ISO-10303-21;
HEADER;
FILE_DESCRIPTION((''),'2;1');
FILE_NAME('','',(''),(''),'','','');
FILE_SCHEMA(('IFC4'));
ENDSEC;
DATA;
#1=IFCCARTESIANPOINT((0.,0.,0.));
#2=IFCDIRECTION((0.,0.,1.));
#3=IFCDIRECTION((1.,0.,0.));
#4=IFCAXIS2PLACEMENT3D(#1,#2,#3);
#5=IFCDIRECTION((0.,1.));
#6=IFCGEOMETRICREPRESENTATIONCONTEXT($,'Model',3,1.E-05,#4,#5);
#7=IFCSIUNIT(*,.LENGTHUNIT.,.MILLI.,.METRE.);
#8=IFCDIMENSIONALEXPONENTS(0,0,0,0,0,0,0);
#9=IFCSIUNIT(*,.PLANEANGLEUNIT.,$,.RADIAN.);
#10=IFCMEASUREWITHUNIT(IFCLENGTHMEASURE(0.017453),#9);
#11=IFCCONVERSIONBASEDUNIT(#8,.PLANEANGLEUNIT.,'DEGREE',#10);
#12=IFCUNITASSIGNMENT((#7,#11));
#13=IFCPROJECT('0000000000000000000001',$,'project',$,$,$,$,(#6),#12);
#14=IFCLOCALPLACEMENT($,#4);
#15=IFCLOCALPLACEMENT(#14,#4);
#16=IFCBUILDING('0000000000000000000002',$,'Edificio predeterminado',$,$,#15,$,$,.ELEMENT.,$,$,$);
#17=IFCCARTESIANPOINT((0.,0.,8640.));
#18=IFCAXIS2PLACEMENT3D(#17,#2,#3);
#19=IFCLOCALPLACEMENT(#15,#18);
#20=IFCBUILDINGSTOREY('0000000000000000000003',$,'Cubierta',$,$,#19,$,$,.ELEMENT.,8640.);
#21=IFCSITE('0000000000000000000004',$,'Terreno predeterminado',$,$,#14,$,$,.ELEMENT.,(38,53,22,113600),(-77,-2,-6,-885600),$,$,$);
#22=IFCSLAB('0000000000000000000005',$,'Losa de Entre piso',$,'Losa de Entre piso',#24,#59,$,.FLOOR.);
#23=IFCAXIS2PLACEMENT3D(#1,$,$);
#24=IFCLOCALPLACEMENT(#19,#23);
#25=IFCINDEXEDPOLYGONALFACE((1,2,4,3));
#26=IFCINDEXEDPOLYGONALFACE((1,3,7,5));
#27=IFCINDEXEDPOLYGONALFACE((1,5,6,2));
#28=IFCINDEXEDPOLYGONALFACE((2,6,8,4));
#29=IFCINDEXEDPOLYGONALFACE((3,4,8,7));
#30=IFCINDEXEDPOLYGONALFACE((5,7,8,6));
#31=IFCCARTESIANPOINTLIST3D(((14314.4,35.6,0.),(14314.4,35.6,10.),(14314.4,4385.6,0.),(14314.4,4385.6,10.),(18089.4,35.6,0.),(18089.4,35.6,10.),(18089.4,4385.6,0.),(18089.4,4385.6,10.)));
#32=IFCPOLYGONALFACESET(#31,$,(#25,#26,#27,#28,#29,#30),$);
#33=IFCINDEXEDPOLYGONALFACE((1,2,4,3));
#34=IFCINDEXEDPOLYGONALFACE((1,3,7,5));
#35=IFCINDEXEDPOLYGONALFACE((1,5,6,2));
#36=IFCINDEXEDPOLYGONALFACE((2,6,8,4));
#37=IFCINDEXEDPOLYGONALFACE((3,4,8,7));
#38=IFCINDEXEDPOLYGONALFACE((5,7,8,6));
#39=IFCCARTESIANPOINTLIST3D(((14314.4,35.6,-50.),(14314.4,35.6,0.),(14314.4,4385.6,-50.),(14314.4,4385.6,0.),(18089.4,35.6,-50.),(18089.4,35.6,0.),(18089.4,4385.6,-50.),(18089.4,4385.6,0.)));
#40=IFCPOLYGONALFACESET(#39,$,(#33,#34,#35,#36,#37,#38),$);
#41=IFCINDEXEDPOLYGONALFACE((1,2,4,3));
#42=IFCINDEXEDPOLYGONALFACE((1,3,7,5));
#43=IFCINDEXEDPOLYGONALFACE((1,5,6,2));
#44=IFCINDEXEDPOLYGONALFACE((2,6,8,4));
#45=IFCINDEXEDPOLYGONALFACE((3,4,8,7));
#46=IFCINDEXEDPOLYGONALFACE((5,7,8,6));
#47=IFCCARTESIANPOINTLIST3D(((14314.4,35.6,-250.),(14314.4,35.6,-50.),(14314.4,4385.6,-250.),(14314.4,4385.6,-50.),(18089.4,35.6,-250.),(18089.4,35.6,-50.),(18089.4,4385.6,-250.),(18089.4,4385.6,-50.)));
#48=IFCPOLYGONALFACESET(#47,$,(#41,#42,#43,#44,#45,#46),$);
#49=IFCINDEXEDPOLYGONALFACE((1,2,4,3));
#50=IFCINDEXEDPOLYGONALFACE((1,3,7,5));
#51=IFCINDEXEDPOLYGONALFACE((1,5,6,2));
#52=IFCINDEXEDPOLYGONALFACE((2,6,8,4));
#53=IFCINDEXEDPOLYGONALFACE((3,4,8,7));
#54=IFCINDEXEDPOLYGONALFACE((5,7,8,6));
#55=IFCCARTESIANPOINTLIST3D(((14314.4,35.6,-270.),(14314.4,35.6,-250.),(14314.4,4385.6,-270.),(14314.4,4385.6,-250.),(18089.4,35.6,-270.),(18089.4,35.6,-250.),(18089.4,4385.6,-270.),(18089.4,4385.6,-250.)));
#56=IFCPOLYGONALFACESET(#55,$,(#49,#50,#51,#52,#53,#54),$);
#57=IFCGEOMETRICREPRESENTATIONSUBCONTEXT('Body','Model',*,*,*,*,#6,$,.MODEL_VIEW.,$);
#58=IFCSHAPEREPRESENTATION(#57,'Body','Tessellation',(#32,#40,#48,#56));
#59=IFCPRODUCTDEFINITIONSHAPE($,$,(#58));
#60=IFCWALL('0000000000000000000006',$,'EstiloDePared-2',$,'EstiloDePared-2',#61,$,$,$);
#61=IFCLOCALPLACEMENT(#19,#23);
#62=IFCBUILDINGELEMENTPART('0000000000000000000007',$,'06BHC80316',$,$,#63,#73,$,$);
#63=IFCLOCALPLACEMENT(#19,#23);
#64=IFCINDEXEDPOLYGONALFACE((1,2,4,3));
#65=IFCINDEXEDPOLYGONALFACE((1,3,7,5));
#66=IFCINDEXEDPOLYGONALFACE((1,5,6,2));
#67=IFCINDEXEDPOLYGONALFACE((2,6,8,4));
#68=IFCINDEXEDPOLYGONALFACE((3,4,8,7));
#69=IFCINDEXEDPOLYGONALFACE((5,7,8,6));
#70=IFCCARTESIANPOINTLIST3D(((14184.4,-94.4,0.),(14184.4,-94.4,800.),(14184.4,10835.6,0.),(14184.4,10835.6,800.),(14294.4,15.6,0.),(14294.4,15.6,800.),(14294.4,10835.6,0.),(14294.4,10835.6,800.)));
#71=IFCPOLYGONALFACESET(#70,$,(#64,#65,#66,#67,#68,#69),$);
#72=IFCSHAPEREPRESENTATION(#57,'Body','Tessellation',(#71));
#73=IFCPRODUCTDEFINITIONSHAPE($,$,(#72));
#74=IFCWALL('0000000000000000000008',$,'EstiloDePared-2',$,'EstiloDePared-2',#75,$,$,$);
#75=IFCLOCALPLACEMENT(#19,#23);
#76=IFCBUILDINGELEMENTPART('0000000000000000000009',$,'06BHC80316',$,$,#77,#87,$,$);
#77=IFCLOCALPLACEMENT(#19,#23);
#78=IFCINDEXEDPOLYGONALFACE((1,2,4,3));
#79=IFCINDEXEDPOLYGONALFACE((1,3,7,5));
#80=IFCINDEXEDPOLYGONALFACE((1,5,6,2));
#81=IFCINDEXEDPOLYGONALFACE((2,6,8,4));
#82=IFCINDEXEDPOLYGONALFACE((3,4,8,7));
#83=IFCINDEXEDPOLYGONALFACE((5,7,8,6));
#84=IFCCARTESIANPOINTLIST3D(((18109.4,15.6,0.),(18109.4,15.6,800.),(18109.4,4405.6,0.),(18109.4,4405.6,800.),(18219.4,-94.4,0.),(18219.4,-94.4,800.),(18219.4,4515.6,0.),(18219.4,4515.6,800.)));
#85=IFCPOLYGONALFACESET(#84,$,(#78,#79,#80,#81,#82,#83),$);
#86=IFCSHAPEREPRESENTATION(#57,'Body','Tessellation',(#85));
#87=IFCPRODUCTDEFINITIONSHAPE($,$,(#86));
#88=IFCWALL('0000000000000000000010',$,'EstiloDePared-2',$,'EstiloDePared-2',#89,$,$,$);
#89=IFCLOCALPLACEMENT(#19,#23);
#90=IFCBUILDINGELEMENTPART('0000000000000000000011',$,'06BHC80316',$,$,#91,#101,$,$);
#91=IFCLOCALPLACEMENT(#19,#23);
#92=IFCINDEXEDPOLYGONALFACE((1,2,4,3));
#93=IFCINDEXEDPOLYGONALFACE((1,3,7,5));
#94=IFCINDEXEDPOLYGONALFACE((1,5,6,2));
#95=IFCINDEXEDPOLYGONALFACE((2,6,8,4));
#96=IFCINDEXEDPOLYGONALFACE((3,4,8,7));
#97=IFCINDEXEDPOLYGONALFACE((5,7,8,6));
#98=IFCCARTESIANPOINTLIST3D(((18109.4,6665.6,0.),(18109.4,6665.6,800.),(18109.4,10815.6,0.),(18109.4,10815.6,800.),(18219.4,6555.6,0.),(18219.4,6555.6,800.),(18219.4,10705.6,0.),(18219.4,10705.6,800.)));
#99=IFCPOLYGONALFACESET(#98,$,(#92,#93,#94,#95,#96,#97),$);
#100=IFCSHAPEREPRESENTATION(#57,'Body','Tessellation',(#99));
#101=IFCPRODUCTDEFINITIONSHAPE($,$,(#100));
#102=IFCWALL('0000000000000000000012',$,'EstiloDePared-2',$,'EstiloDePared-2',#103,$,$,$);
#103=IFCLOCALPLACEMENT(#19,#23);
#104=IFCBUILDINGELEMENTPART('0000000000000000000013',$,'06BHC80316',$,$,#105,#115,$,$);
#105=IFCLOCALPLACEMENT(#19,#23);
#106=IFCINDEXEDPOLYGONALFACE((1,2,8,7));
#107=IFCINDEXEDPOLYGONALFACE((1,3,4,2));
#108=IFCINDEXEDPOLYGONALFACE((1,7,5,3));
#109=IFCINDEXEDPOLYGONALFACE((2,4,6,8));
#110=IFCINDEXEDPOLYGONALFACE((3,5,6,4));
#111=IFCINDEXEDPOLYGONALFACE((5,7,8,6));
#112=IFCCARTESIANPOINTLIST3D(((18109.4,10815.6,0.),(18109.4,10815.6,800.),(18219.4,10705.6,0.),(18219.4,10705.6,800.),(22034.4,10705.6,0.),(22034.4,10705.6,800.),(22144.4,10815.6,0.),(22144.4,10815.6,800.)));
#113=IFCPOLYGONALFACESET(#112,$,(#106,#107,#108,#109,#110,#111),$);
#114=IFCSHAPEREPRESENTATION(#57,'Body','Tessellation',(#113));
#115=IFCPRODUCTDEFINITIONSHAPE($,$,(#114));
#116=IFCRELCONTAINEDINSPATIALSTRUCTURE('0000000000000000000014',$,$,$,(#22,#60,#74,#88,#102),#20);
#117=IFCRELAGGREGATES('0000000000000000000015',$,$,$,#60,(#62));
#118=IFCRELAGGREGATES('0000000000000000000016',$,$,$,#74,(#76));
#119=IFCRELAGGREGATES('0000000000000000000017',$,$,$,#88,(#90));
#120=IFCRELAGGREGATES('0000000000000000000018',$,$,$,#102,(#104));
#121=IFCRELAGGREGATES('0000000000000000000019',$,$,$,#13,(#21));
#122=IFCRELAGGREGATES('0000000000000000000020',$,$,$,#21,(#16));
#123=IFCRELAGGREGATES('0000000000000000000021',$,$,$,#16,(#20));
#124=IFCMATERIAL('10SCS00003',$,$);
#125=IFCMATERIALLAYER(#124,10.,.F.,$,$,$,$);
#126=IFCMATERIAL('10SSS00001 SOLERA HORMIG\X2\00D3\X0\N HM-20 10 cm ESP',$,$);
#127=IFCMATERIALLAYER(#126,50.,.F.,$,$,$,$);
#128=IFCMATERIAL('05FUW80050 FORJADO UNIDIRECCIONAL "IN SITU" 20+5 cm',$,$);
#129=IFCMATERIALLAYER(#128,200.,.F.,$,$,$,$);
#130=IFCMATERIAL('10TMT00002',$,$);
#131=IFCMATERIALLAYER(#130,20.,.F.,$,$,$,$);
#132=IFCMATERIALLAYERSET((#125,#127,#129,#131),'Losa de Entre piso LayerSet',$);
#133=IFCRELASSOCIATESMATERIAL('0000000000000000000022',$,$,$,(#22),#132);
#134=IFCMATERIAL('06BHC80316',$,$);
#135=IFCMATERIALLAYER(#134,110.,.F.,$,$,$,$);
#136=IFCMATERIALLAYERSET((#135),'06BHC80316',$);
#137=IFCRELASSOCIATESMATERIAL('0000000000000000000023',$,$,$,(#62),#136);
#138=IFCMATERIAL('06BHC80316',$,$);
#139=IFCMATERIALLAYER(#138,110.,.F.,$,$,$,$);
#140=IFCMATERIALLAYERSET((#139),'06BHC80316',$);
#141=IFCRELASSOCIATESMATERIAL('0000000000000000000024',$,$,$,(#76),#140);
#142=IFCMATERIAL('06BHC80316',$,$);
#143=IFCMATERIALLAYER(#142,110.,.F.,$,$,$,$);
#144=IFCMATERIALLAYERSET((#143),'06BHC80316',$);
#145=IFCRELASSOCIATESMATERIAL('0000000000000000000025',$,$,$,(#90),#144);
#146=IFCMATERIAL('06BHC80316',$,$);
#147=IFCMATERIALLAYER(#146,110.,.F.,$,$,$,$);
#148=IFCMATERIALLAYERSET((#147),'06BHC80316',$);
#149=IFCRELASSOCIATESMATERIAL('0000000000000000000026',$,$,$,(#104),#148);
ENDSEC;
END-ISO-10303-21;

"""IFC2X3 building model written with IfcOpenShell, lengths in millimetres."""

from ifc_helpers import new_model, entity, si_unit, converted_unit, direction, frame, origin_with_axes, place, context, subcontext, project, spatial, polyline, outline, extrude, material, layer, layer_set, layer_usage, element, aggregate, save


model = new_model("IFC2X3")

# Units and contexts
model_context = context("Model", 3, precision=1e-05, world=origin_with_axes(), true_north=direction((0.0, 1.0)))
body_context = subcontext(model_context, "Body", "Model", "MODEL_VIEW")
ifc_project = project(units=[si_unit("LENGTHUNIT", "METRE", prefix="MILLI"), converted_unit("PLANEANGLEUNIT", "DEGREE", entity("IfcLengthMeasure", 0.017453), si_unit("PLANEANGLEUNIT", "RADIAN"), dimensions=[0, 0, 0, 0, 0, 0, 0])], contexts=[model_context])

# Site, building, storey
site_placement = place(None, origin_with_axes())
site = spatial("IfcSite", under=ifc_project, at=site_placement, Name="Terreno predeterminado", CompositionType="ELEMENT", RefLatitude=(38, 53, 22, 113600), RefLongitude=(-77, -2, -6, -885600))
building_placement = place(site_placement, origin_with_axes())
building = spatial("IfcBuilding", under=site, at=building_placement, Name="Edificio predeterminado", CompositionType="ELEMENT")
storey_placement = place(building_placement, frame((0.0, 0.0, 8640.0), z_axis=(0.0, 0.0, 1.0), x_axis=(1.0, 0.0, 0.0)))
storey = spatial("IfcBuildingStorey", under=building, at=storey_placement, Name="Cubierta", CompositionType="ELEMENT", Elevation=8640.0)

# Slab
ifc_material_1 = material(Name="10SCS00003")
ifc_layer_1 = layer(ifc_material_1, 10.0, ventilated=False)
ifc_material_2 = material(Name="10SSS00001 SOLERA HORMIGÓN HM-20 10 cm ESP")
ifc_layer_2 = layer(ifc_material_2, 50.0, ventilated=False)
ifc_material_3 = material(Name="05FUW80050 FORJADO UNIDIRECCIONAL \"IN SITU\" 20+5 cm")
ifc_layer_3 = layer(ifc_material_3, 200.0, ventilated=False)
ifc_material_4 = material(Name="10TMT00002")
ifc_layer_4 = layer(ifc_material_4, 20.0, ventilated=False)
ifc_layer_set_1 = layer_set([ifc_layer_1, ifc_layer_2, ifc_layer_3, ifc_layer_4], Name="Losa de Entre piso LayerSet")
ifc_layer_usage_1 = layer_usage(ifc_layer_set_1, "AXIS3", "NEGATIVE", 0.0)
slab_1_placement = place(storey_placement, frame((0.0, 0.0, -8640.0), z_axis=(0.0, 0.0, 1.0), x_axis=(1.0, 0.0, 0.0)))
element("IfcSlab", 1, at=slab_1_placement, inside=storey, material=ifc_layer_usage_1, Name="Losa de Entre piso", ObjectType="Losa de Entre piso", PredefinedType="FLOOR", context=body_context, shape_type="SweptSolid", body=[
    extrude(outline(polyline([(0.0, 4350.0), (3775.0, 4350.0), (3775.0, 0.0), (0.0, 0.0), (0.0, 4350.0)])), frame((18089.4, 35.6, 8640.0), z_axis=(0.0, 0.0, -1.0), x_axis=(-1.0, 0.0, 0.0)), (0.0, 0.0, -1.0), 10.0),
    extrude(outline(polyline([(0.0, 4350.0), (3775.0, 4350.0), (3775.0, 0.0), (0.0, 0.0), (0.0, 4350.0)])), frame((18089.4, 35.6, 8590.0), z_axis=(0.0, 0.0, -1.0), x_axis=(-1.0, 0.0, 0.0)), (0.0, 0.0, -1.0), 50.0),
    extrude(outline(polyline([(0.0, 4350.0), (3775.0, 4350.0), (3775.0, 0.0), (0.0, 0.0), (0.0, 4350.0)])), frame((18089.4, 35.6, 8390.0), z_axis=(0.0, 0.0, -1.0), x_axis=(-1.0, 0.0, 0.0)), (0.0, 0.0, -1.0), 200.0),
    extrude(outline(polyline([(0.0, 4350.0), (3775.0, 4350.0), (3775.0, 0.0), (0.0, 0.0), (0.0, 4350.0)])), frame((18089.4, 35.6, 8370.0), z_axis=(0.0, 0.0, -1.0), x_axis=(-1.0, 0.0, 0.0)), (0.0, 0.0, -1.0), 20.0),
])

# Walls, building element parts
wall_1_placement = place(storey_placement, frame((14239.4, -39.4, 0.0), z_axis=(0.0, 0.0, 1.0), x_axis=(0.0, 1.0, 0.0)))
wall_1 = element("IfcWall", 2, at=wall_1_placement, inside=storey, Name="EstiloDePared-2", ObjectType="EstiloDePared-2")
ifc_material_5 = material(Name="06BHC80316")
ifc_layer_5 = layer(ifc_material_5, 110.0, ventilated=False)
ifc_layer_set_2 = layer_set([ifc_layer_5], Name="06BHC80316")
ifc_layer_usage_2 = layer_usage(ifc_layer_set_2, "AXIS2", "NEGATIVE", -55.0)
building_element_part_1_placement = place(wall_1_placement, origin_with_axes())
building_element_part_1 = element("IfcBuildingElementPart", 3, at=building_element_part_1_placement, material=ifc_layer_usage_2, Name="06BHC80316", context=body_context, shape_type="SweptSolid", body=[
    extrude(outline(polyline([(10875.0, 55.0), (10875.0, -55.0), (55.0, -55.0), (-55.0, 55.0), (10875.0, 55.0)])), origin_with_axes(), (0.0, 0.0, 1.0), 800.0),
])
aggregate(wall_1, [building_element_part_1])
wall_2_placement = place(storey_placement, frame((18164.4, -39.4, 0.0), z_axis=(0.0, 0.0, 1.0), x_axis=(0.0, 1.0, 0.0)))
wall_2 = element("IfcWall", 4, at=wall_2_placement, inside=storey, Name="EstiloDePared-2", ObjectType="EstiloDePared-2")
ifc_material_6 = material(Name="06BHC80316")
ifc_layer_6 = layer(ifc_material_6, 110.0, ventilated=False)
ifc_layer_set_3 = layer_set([ifc_layer_6], Name="06BHC80316")
ifc_layer_usage_3 = layer_usage(ifc_layer_set_3, "AXIS2", "NEGATIVE", -55.0)
building_element_part_2_placement = place(wall_2_placement, origin_with_axes())
building_element_part_2 = element("IfcBuildingElementPart", 5, at=building_element_part_2_placement, material=ifc_layer_usage_3, Name="06BHC80316", context=body_context, shape_type="SweptSolid", body=[
    extrude(outline(polyline([(4445.0, 55.0), (4555.0, -55.0), (-55.0, -55.0), (55.0, 55.0), (4445.0, 55.0)])), origin_with_axes(), (0.0, 0.0, 1.0), 800.0),
])
aggregate(wall_2, [building_element_part_2])
wall_3_placement = place(storey_placement, frame((18164.4, 6610.6, 0.0), z_axis=(0.0, 0.0, 1.0), x_axis=(0.0, 1.0, 0.0)))
wall_3 = element("IfcWall", 6, at=wall_3_placement, inside=storey, Name="EstiloDePared-2", ObjectType="EstiloDePared-2")
ifc_material_7 = material(Name="06BHC80316")
ifc_layer_7 = layer(ifc_material_7, 110.0, ventilated=False)
ifc_layer_set_4 = layer_set([ifc_layer_7], Name="06BHC80316")
ifc_layer_usage_4 = layer_usage(ifc_layer_set_4, "AXIS2", "NEGATIVE", -55.0)
building_element_part_3_placement = place(wall_3_placement, origin_with_axes())
building_element_part_3 = element("IfcBuildingElementPart", 7, at=building_element_part_3_placement, material=ifc_layer_usage_4, Name="06BHC80316", context=body_context, shape_type="SweptSolid", body=[
    extrude(outline(polyline([(4205.0, 55.0), (4095.0, -55.0), (-55.0, -55.0), (55.0, 55.0), (4205.0, 55.0)])), origin_with_axes(), (0.0, 0.0, 1.0), 800.0),
])
aggregate(wall_3, [building_element_part_3])
wall_4_placement = place(storey_placement, frame((18164.4, 10760.6, 0.0), z_axis=(0.0, 0.0, 1.0), x_axis=(1.0, 0.0, 0.0)))
wall_4 = element("IfcWall", 8, at=wall_4_placement, inside=storey, Name="EstiloDePared-2", ObjectType="EstiloDePared-2")
ifc_material_8 = material(Name="06BHC80316")
ifc_layer_8 = layer(ifc_material_8, 110.0, ventilated=False)
ifc_layer_set_5 = layer_set([ifc_layer_8], Name="06BHC80316")
ifc_layer_usage_5 = layer_usage(ifc_layer_set_5, "AXIS2", "NEGATIVE", -55.0)
building_element_part_4_placement = place(wall_4_placement, origin_with_axes())
building_element_part_4 = element("IfcBuildingElementPart", 9, at=building_element_part_4_placement, material=ifc_layer_usage_5, Name="06BHC80316", context=body_context, shape_type="SweptSolid", body=[
    extrude(outline(polyline([(3980.0, 55.0), (3870.0, -55.0), (55.0, -55.0), (-55.0, 55.0), (3980.0, 55.0)])), origin_with_axes(), (0.0, 0.0, 1.0), 800.0),
])
aggregate(wall_4, [building_element_part_4])

save(model, "model.ifc")
